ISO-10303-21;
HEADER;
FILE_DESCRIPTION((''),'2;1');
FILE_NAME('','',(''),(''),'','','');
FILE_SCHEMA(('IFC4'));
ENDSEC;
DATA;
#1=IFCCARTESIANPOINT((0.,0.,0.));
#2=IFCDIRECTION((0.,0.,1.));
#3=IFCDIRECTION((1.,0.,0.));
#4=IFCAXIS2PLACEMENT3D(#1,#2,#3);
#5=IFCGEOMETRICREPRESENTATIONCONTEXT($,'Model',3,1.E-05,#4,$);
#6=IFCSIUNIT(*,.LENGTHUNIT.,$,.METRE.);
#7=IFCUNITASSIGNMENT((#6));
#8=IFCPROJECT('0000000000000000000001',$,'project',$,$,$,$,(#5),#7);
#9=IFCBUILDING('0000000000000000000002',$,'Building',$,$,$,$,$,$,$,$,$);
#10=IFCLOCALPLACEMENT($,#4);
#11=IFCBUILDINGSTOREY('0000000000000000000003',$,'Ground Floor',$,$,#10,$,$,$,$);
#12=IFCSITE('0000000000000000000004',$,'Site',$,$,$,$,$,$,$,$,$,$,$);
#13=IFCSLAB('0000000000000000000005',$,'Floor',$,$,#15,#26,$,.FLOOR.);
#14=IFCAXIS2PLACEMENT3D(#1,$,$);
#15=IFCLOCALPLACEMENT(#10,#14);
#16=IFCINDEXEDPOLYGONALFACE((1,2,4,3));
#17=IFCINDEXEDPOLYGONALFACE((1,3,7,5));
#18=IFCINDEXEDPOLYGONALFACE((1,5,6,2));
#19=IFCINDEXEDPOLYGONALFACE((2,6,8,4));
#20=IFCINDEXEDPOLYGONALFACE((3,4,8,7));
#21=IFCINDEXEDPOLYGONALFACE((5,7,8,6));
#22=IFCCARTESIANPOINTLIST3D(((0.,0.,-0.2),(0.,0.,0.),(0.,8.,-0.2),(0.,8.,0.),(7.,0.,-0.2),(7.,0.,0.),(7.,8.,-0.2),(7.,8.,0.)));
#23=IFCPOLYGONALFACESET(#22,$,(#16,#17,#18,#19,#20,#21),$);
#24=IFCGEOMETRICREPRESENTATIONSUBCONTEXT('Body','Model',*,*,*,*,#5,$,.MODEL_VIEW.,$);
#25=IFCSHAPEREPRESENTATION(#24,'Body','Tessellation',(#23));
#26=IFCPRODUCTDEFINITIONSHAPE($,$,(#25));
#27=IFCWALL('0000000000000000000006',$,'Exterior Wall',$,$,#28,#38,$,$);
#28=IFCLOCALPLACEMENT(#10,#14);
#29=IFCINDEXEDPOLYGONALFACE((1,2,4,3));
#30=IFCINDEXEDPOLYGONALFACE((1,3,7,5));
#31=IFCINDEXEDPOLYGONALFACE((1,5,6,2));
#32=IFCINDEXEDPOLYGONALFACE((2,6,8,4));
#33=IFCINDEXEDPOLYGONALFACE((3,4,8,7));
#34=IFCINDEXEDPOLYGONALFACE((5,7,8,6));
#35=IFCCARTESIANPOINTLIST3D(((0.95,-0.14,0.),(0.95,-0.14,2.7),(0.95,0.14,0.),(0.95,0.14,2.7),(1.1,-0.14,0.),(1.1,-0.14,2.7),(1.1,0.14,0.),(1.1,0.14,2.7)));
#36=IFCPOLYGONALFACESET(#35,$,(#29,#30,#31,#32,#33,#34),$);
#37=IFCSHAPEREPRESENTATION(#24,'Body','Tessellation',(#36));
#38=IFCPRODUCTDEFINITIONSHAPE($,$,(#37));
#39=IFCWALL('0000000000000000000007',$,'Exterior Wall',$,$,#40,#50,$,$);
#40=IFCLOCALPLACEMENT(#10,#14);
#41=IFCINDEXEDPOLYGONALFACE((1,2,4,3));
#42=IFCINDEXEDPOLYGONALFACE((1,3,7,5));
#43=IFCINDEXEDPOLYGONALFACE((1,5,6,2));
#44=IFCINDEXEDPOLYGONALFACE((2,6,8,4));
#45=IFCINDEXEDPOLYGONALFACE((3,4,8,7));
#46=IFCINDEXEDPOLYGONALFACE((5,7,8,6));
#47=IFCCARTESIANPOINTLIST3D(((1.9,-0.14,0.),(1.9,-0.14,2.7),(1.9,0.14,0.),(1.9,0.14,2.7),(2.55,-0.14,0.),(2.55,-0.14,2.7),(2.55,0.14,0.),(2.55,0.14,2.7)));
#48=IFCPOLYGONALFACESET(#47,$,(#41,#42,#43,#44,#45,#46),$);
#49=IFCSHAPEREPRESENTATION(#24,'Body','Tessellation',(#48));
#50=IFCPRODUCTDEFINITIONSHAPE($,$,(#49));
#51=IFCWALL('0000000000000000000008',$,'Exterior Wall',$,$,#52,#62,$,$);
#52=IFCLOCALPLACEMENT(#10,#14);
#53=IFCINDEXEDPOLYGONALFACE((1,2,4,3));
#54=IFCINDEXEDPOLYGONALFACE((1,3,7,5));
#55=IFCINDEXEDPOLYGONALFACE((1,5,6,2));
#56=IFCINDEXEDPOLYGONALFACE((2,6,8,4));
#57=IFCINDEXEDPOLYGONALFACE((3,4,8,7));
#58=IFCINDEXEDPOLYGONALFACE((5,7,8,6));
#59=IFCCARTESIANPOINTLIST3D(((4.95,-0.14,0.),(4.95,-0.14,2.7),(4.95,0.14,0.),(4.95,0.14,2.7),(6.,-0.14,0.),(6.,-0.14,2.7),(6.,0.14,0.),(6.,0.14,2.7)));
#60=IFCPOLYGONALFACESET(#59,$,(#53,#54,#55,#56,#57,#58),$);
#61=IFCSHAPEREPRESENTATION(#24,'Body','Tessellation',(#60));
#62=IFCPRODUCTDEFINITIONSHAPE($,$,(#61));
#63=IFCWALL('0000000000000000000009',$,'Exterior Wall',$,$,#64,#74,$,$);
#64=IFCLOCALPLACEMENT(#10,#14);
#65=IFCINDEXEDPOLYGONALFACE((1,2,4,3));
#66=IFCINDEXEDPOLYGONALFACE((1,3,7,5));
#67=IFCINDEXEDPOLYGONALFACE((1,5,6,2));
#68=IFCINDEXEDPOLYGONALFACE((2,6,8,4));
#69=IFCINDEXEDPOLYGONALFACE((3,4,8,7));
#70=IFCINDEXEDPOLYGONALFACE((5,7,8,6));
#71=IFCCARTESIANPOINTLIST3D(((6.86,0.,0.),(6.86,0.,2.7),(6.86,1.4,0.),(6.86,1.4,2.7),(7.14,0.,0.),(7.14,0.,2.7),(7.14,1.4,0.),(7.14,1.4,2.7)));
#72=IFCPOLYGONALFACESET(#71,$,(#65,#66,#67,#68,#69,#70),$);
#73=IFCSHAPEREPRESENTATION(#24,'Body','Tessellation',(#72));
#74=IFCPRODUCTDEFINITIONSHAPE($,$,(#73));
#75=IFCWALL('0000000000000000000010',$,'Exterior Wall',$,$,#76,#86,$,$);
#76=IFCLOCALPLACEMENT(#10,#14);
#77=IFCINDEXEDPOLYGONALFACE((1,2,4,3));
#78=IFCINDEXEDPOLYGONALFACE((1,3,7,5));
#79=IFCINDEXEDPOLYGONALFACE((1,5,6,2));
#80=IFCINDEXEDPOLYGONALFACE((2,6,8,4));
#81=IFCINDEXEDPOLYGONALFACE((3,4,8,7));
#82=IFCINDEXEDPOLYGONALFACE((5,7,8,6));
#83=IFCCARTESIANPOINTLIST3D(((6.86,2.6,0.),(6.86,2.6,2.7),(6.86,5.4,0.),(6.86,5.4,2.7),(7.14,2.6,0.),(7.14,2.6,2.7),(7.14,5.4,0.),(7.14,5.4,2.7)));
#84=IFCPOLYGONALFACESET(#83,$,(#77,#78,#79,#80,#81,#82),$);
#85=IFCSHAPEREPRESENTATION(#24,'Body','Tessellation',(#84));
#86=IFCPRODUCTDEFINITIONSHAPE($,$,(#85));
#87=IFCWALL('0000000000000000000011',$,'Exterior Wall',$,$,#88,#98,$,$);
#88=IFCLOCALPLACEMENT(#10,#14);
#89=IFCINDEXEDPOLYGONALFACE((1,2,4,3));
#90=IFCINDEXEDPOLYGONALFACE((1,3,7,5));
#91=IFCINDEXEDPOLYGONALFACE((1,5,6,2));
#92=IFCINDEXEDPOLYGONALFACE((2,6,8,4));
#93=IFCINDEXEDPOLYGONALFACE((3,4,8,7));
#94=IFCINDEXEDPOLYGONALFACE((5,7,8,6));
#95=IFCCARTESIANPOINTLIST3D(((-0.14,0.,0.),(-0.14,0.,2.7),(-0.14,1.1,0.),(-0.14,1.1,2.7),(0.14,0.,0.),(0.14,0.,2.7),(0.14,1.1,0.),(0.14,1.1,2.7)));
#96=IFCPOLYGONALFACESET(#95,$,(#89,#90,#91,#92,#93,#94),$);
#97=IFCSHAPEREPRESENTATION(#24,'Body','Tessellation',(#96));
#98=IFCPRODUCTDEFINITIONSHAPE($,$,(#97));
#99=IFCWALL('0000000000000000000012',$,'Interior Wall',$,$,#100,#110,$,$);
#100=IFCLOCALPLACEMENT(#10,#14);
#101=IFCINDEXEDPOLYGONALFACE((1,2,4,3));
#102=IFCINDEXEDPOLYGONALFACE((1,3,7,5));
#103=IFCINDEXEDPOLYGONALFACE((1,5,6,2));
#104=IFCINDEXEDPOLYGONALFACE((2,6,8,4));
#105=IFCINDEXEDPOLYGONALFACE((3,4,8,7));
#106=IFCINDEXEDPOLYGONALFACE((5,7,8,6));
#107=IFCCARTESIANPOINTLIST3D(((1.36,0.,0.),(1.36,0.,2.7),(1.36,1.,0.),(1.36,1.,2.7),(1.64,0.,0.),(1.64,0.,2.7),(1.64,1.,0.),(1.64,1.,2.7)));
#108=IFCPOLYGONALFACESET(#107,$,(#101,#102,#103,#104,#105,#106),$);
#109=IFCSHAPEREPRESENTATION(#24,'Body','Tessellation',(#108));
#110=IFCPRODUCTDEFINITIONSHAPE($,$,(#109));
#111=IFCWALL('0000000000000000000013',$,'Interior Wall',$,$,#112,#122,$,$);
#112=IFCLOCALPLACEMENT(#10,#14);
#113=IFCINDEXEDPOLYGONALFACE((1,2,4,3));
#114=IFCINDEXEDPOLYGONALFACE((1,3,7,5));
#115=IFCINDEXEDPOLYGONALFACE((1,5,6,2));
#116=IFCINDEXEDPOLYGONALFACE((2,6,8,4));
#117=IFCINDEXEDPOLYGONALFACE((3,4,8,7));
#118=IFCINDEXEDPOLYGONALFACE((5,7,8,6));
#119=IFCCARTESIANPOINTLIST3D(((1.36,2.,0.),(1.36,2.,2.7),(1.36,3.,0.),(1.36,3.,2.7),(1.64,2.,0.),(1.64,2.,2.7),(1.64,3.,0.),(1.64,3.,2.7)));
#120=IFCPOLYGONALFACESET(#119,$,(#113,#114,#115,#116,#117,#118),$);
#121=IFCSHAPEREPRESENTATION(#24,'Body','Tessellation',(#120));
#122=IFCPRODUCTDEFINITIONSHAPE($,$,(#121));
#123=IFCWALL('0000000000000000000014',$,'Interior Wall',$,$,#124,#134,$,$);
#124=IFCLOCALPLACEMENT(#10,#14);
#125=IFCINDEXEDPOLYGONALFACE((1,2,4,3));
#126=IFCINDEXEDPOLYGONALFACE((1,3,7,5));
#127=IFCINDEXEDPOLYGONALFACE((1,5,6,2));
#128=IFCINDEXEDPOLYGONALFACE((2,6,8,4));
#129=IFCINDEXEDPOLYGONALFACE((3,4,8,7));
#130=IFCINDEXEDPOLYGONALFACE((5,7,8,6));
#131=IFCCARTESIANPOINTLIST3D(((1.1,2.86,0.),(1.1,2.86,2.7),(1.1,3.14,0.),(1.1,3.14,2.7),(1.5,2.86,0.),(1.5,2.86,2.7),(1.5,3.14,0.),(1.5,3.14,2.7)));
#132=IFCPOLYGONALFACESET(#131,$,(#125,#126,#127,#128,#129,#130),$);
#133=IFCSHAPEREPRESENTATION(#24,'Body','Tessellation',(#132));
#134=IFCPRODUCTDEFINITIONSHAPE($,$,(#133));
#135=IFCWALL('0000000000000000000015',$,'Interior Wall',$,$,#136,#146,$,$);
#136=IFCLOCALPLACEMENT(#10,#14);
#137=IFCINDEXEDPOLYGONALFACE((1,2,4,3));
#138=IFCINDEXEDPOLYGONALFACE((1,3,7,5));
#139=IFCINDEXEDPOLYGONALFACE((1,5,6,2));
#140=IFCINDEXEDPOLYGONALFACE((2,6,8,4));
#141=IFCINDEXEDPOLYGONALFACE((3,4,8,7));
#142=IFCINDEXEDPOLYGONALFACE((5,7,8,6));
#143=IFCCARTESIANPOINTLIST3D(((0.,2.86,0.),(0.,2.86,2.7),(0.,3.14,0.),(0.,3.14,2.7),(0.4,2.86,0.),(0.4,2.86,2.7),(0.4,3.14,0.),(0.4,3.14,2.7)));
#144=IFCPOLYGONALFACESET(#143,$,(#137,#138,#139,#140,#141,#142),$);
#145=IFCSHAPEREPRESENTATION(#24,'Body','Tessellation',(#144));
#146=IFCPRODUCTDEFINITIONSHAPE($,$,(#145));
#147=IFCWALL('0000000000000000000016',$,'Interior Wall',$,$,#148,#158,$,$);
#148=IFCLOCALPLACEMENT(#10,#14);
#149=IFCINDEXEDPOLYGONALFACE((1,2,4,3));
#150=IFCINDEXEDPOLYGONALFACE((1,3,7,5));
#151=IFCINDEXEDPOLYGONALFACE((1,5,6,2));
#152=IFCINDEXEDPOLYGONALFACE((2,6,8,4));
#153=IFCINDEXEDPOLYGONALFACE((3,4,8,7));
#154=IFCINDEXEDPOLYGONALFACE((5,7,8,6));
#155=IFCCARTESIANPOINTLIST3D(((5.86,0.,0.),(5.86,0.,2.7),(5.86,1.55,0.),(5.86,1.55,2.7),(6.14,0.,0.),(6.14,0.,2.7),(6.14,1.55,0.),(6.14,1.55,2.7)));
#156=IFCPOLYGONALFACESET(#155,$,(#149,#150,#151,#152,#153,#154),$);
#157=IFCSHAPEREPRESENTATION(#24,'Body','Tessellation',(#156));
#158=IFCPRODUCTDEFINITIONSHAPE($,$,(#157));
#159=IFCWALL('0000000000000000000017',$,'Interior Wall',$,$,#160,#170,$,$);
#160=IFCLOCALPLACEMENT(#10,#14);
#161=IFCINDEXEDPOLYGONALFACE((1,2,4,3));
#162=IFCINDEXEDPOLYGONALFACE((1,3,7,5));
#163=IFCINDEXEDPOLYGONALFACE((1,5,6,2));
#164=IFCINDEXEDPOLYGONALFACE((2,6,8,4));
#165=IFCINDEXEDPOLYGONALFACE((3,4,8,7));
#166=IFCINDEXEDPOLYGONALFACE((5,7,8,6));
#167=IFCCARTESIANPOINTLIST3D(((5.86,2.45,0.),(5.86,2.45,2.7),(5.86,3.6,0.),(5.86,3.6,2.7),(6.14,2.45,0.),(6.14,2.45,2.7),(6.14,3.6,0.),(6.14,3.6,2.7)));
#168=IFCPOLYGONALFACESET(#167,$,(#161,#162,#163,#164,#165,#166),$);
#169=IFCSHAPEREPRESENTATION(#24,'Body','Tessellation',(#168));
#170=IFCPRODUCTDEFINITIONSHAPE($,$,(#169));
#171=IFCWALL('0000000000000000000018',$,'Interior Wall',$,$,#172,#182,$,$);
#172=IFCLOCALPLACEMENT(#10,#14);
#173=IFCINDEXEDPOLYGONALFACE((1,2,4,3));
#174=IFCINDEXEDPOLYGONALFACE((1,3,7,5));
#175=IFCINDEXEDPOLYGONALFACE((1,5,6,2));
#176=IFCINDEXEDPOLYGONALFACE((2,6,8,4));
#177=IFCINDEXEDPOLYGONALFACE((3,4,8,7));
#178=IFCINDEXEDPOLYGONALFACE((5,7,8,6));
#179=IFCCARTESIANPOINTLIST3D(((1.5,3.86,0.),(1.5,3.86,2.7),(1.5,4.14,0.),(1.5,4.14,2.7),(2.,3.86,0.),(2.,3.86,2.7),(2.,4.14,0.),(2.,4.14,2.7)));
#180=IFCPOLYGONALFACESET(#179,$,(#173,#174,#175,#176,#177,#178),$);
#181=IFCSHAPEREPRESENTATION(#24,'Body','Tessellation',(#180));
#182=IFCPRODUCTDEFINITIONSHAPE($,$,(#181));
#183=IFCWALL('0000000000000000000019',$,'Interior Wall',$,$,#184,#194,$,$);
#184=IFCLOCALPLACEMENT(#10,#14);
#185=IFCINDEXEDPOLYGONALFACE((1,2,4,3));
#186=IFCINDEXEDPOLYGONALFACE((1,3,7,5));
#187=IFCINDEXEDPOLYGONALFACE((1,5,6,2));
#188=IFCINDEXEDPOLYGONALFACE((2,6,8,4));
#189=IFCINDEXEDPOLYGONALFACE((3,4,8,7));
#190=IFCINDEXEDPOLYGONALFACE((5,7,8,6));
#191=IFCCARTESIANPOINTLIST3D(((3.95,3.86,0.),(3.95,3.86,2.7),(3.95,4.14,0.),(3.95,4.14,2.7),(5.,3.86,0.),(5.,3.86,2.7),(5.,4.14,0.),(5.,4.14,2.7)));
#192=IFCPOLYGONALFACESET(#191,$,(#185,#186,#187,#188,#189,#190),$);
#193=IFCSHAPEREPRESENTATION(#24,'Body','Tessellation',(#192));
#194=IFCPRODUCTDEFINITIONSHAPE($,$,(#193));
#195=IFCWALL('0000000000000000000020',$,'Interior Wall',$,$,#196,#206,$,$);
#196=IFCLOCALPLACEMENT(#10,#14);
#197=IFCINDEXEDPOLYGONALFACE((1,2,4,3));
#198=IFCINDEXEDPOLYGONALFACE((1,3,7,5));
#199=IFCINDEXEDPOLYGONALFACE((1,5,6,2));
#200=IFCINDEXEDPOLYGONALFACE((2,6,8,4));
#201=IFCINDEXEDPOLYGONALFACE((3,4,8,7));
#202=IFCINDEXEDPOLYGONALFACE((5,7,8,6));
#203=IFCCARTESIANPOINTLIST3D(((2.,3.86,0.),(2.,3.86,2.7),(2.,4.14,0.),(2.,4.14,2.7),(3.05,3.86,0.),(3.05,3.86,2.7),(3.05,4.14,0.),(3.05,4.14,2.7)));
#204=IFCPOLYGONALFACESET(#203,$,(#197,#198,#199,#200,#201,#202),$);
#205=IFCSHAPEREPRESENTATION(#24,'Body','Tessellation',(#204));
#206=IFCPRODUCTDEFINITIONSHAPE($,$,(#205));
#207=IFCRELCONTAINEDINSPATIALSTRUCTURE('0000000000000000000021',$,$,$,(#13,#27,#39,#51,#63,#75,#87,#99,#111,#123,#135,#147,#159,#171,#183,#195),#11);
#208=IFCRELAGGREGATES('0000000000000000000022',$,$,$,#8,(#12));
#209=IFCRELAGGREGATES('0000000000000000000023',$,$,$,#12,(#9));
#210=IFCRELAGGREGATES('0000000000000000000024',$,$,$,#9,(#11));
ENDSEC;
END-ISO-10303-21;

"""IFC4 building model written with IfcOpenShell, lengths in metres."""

from ifc_helpers import new_model, si_unit, frame, origin_with_axes, place, context, subcontext, project, spatial, indexed_curve, outline, extrude, element, save


model = new_model("IFC4")

# Units and contexts
model_context = context("Model", 3, precision=1e-05, world=origin_with_axes())
body_context = subcontext(model_context, "Body", "Model", "MODEL_VIEW")
ifc_project = project(units=[si_unit("LENGTHUNIT", "METRE")], contexts=[model_context])

# Site, building, storey
site = spatial("IfcSite", under=ifc_project, Name="Site")
building = spatial("IfcBuilding", under=site, Name="Building")
storey_placement = place(None, origin_with_axes())
storey = spatial("IfcBuildingStorey", under=building, at=storey_placement, Name="Ground Floor")

# Slab
slab_placement = place(storey_placement, frame((0.0, 0.0, -0.2), z_axis=(0.0, 0.0, 1.0), x_axis=(1.0, 0.0, 0.0)))
element("IfcSlab", 1, at=slab_placement, inside=storey, Name="Floor", PredefinedType="FLOOR", context=body_context, shape_type="SweptSolid", body=[
    extrude(outline(indexed_curve([(0.0, 0.0), (7.0, 0.0), (7.0, 8.0), (0.0, 8.0)])), None, (0.0, 0.0, 1.0), 0.2),
])

# Walls
wall_1_placement = place(storey_placement, frame((0.95, 0.0, 0.0), z_axis=(0.0, 0.0, 1.0), x_axis=(1.0, 0.0, 0.0)))
element("IfcWall", 2, at=wall_1_placement, inside=storey, Name="Exterior Wall", context=body_context, shape_type="SweptSolid", body=[
    extrude(outline(indexed_curve([(0.0, 0.0), (0.0, 0.28), (0.15, 0.28), (0.15, 0.0), (0.0, 0.0)], self_intersect=False)), frame((0.0, -0.14, 0.0), z_axis=(0.0, 0.0, 1.0), x_axis=(1.0, 0.0, 0.0)), (0.0, 0.0, 1.0), 2.7),
])
wall_2_placement = place(storey_placement, frame((1.9, 0.0, 0.0), z_axis=(0.0, 0.0, 1.0), x_axis=(1.0, 0.0, 0.0)))
element("IfcWall", 3, at=wall_2_placement, inside=storey, Name="Exterior Wall", context=body_context, shape_type="SweptSolid", body=[
    extrude(outline(indexed_curve([(0.0, 0.0), (0.0, 0.28), (0.65, 0.28), (0.65, 0.0), (0.0, 0.0)], self_intersect=False)), frame((0.0, -0.14, 0.0), z_axis=(0.0, 0.0, 1.0), x_axis=(1.0, 0.0, 0.0)), (0.0, 0.0, 1.0), 2.7),
])
wall_3_placement = place(storey_placement, frame((4.95, 0.0, 0.0), z_axis=(0.0, 0.0, 1.0), x_axis=(1.0, 0.0, 0.0)))
element("IfcWall", 4, at=wall_3_placement, inside=storey, Name="Exterior Wall", context=body_context, shape_type="SweptSolid", body=[
    extrude(outline(indexed_curve([(0.0, 0.0), (0.0, 0.28), (1.05, 0.28), (1.05, 0.0), (0.0, 0.0)], self_intersect=False)), frame((0.0, -0.14, 0.0), z_axis=(0.0, 0.0, 1.0), x_axis=(1.0, 0.0, 0.0)), (0.0, 0.0, 1.0), 2.7),
])
wall_4_placement = place(storey_placement, frame((7.0, 0.0, 0.0), z_axis=(0.0, 0.0, 1.0), x_axis=(0.0, 1.0, 0.0)))
element("IfcWall", 5, at=wall_4_placement, inside=storey, Name="Exterior Wall", context=body_context, shape_type="SweptSolid", body=[
    extrude(outline(indexed_curve([(0.0, 0.0), (0.0, 0.28), (1.4, 0.28), (1.4, 0.0), (0.0, 0.0)], self_intersect=False)), frame((0.0, -0.14, 0.0), z_axis=(0.0, 0.0, 1.0), x_axis=(1.0, 0.0, 0.0)), (0.0, 0.0, 1.0), 2.7),
])
wall_5_placement = place(storey_placement, frame((7.0, 2.6, 0.0), z_axis=(0.0, 0.0, 1.0), x_axis=(0.0, 1.0, 0.0)))
element("IfcWall", 6, at=wall_5_placement, inside=storey, Name="Exterior Wall", context=body_context, shape_type="SweptSolid", body=[
    extrude(outline(indexed_curve([(0.0, 0.0), (0.0, 0.28), (2.8, 0.28), (2.8, 0.0), (0.0, 0.0)], self_intersect=False)), frame((0.0, -0.14, 0.0), z_axis=(0.0, 0.0, 1.0), x_axis=(1.0, 0.0, 0.0)), (0.0, 0.0, 1.0), 2.7),
])
wall_6_placement = place(storey_placement, frame((0.0, 1.1, 0.0), z_axis=(0.0, 0.0, 1.0), x_axis=(0.0, -1.0, 0.0)))
element("IfcWall", 7, at=wall_6_placement, inside=storey, Name="Exterior Wall", context=body_context, shape_type="SweptSolid", body=[
    extrude(outline(indexed_curve([(0.0, 0.0), (0.0, 0.28), (1.1, 0.28), (1.1, 0.0), (0.0, 0.0)], self_intersect=False)), frame((0.0, -0.14, 0.0), z_axis=(0.0, 0.0, 1.0), x_axis=(1.0, 0.0, 0.0)), (0.0, 0.0, 1.0), 2.7),
])
for number, where, z_axis, x_axis, name in (
    (8, (1.5, 0.0, 0.0), (0.0, 0.0, 1.0), (0.0, 1.0, 0.0), "Interior Wall"),
    (9, (1.5, 2.0, 0.0), (0.0, 0.0, 1.0), (0.0, 1.0, 0.0), "Interior Wall"),
):
    element("IfcWall", number, at=place(storey_placement, frame(where, z_axis=z_axis, x_axis=x_axis)), inside=storey, Name=name, context=body_context, shape_type="SweptSolid", body=[
        extrude(outline(indexed_curve([(0.0, 0.0), (0.0, 0.28), (1.0, 0.28), (1.0, 0.0), (0.0, 0.0)], self_intersect=False)), frame((0.0, -0.14, 0.0), z_axis=(0.0, 0.0, 1.0), x_axis=(1.0, 0.0, 0.0)), (0.0, 0.0, 1.0), 2.7),
    ])
for number, where, z_axis, x_axis, name in (
    (10, (1.5, 3.0, 0.0), (0.0, 0.0, 1.0), (-1.0, 0.0, 0.0), "Interior Wall"),
    (11, (0.4, 3.0, 0.0), (0.0, 0.0, 1.0), (-1.0, 0.0, 0.0), "Interior Wall"),
):
    element("IfcWall", number, at=place(storey_placement, frame(where, z_axis=z_axis, x_axis=x_axis)), inside=storey, Name=name, context=body_context, shape_type="SweptSolid", body=[
        extrude(outline(indexed_curve([(0.0, 0.0), (0.0, 0.28), (0.4, 0.28), (0.4, 0.0), (0.0, 0.0)], self_intersect=False)), frame((0.0, -0.14, 0.0), z_axis=(0.0, 0.0, 1.0), x_axis=(1.0, 0.0, 0.0)), (0.0, 0.0, 1.0), 2.7),
    ])
wall_7_placement = place(storey_placement, frame((6.0, 0.0, 0.0), z_axis=(0.0, 0.0, 1.0), x_axis=(0.0, 1.0, 0.0)))
element("IfcWall", 12, at=wall_7_placement, inside=storey, Name="Interior Wall", context=body_context, shape_type="SweptSolid", body=[
    extrude(outline(indexed_curve([(0.0, 0.0), (0.0, 0.28), (1.55, 0.28), (1.55, 0.0), (0.0, 0.0)], self_intersect=False)), frame((0.0, -0.14, 0.0), z_axis=(0.0, 0.0, 1.0), x_axis=(1.0, 0.0, 0.0)), (0.0, 0.0, 1.0), 2.7),
])
wall_8_placement = place(storey_placement, frame((6.0, 2.45, 0.0), z_axis=(0.0, 0.0, 1.0), x_axis=(0.0, 1.0, 0.0)))
element("IfcWall", 13, at=wall_8_placement, inside=storey, Name="Interior Wall", context=body_context, shape_type="SweptSolid", body=[
    extrude(outline(indexed_curve([(0.0, 0.0), (0.0, 0.28), (1.15, 0.28), (1.15, 0.0), (0.0, 0.0)], self_intersect=False)), frame((0.0, -0.14, 0.0), z_axis=(0.0, 0.0, 1.0), x_axis=(1.0, 0.0, 0.0)), (0.0, 0.0, 1.0), 2.7),
])
wall_9_placement = place(storey_placement, frame((2.0, 4.0, 0.0), z_axis=(0.0, 0.0, 1.0), x_axis=(-1.0, 0.0, 0.0)))
element("IfcWall", 14, at=wall_9_placement, inside=storey, Name="Interior Wall", context=body_context, shape_type="SweptSolid", body=[
    extrude(outline(indexed_curve([(0.0, 0.0), (0.0, 0.28), (0.5, 0.28), (0.5, 0.0), (0.0, 0.0)], self_intersect=False)), frame((0.0, -0.14, 0.0), z_axis=(0.0, 0.0, 1.0), x_axis=(1.0, 0.0, 0.0)), (0.0, 0.0, 1.0), 2.7),
])
for number, where, z_axis, x_axis, name in (
    (15, (5.0, 4.0, 0.0), (0.0, 0.0, 1.0), (-1.0, 0.0, 0.0), "Interior Wall"),
    (16, (3.05, 4.0, 0.0), (0.0, 0.0, 1.0), (-1.0, 0.0, 0.0), "Interior Wall"),
):
    element("IfcWall", number, at=place(storey_placement, frame(where, z_axis=z_axis, x_axis=x_axis)), inside=storey, Name=name, context=body_context, shape_type="SweptSolid", body=[
        extrude(outline(indexed_curve([(0.0, 0.0), (0.0, 0.28), (1.05, 0.28), (1.05, 0.0), (0.0, 0.0)], self_intersect=False)), frame((0.0, -0.14, 0.0), z_axis=(0.0, 0.0, 1.0), x_axis=(1.0, 0.0, 0.0)), (0.0, 0.0, 1.0), 2.7),
    ])

save(model, "model.ifc")
